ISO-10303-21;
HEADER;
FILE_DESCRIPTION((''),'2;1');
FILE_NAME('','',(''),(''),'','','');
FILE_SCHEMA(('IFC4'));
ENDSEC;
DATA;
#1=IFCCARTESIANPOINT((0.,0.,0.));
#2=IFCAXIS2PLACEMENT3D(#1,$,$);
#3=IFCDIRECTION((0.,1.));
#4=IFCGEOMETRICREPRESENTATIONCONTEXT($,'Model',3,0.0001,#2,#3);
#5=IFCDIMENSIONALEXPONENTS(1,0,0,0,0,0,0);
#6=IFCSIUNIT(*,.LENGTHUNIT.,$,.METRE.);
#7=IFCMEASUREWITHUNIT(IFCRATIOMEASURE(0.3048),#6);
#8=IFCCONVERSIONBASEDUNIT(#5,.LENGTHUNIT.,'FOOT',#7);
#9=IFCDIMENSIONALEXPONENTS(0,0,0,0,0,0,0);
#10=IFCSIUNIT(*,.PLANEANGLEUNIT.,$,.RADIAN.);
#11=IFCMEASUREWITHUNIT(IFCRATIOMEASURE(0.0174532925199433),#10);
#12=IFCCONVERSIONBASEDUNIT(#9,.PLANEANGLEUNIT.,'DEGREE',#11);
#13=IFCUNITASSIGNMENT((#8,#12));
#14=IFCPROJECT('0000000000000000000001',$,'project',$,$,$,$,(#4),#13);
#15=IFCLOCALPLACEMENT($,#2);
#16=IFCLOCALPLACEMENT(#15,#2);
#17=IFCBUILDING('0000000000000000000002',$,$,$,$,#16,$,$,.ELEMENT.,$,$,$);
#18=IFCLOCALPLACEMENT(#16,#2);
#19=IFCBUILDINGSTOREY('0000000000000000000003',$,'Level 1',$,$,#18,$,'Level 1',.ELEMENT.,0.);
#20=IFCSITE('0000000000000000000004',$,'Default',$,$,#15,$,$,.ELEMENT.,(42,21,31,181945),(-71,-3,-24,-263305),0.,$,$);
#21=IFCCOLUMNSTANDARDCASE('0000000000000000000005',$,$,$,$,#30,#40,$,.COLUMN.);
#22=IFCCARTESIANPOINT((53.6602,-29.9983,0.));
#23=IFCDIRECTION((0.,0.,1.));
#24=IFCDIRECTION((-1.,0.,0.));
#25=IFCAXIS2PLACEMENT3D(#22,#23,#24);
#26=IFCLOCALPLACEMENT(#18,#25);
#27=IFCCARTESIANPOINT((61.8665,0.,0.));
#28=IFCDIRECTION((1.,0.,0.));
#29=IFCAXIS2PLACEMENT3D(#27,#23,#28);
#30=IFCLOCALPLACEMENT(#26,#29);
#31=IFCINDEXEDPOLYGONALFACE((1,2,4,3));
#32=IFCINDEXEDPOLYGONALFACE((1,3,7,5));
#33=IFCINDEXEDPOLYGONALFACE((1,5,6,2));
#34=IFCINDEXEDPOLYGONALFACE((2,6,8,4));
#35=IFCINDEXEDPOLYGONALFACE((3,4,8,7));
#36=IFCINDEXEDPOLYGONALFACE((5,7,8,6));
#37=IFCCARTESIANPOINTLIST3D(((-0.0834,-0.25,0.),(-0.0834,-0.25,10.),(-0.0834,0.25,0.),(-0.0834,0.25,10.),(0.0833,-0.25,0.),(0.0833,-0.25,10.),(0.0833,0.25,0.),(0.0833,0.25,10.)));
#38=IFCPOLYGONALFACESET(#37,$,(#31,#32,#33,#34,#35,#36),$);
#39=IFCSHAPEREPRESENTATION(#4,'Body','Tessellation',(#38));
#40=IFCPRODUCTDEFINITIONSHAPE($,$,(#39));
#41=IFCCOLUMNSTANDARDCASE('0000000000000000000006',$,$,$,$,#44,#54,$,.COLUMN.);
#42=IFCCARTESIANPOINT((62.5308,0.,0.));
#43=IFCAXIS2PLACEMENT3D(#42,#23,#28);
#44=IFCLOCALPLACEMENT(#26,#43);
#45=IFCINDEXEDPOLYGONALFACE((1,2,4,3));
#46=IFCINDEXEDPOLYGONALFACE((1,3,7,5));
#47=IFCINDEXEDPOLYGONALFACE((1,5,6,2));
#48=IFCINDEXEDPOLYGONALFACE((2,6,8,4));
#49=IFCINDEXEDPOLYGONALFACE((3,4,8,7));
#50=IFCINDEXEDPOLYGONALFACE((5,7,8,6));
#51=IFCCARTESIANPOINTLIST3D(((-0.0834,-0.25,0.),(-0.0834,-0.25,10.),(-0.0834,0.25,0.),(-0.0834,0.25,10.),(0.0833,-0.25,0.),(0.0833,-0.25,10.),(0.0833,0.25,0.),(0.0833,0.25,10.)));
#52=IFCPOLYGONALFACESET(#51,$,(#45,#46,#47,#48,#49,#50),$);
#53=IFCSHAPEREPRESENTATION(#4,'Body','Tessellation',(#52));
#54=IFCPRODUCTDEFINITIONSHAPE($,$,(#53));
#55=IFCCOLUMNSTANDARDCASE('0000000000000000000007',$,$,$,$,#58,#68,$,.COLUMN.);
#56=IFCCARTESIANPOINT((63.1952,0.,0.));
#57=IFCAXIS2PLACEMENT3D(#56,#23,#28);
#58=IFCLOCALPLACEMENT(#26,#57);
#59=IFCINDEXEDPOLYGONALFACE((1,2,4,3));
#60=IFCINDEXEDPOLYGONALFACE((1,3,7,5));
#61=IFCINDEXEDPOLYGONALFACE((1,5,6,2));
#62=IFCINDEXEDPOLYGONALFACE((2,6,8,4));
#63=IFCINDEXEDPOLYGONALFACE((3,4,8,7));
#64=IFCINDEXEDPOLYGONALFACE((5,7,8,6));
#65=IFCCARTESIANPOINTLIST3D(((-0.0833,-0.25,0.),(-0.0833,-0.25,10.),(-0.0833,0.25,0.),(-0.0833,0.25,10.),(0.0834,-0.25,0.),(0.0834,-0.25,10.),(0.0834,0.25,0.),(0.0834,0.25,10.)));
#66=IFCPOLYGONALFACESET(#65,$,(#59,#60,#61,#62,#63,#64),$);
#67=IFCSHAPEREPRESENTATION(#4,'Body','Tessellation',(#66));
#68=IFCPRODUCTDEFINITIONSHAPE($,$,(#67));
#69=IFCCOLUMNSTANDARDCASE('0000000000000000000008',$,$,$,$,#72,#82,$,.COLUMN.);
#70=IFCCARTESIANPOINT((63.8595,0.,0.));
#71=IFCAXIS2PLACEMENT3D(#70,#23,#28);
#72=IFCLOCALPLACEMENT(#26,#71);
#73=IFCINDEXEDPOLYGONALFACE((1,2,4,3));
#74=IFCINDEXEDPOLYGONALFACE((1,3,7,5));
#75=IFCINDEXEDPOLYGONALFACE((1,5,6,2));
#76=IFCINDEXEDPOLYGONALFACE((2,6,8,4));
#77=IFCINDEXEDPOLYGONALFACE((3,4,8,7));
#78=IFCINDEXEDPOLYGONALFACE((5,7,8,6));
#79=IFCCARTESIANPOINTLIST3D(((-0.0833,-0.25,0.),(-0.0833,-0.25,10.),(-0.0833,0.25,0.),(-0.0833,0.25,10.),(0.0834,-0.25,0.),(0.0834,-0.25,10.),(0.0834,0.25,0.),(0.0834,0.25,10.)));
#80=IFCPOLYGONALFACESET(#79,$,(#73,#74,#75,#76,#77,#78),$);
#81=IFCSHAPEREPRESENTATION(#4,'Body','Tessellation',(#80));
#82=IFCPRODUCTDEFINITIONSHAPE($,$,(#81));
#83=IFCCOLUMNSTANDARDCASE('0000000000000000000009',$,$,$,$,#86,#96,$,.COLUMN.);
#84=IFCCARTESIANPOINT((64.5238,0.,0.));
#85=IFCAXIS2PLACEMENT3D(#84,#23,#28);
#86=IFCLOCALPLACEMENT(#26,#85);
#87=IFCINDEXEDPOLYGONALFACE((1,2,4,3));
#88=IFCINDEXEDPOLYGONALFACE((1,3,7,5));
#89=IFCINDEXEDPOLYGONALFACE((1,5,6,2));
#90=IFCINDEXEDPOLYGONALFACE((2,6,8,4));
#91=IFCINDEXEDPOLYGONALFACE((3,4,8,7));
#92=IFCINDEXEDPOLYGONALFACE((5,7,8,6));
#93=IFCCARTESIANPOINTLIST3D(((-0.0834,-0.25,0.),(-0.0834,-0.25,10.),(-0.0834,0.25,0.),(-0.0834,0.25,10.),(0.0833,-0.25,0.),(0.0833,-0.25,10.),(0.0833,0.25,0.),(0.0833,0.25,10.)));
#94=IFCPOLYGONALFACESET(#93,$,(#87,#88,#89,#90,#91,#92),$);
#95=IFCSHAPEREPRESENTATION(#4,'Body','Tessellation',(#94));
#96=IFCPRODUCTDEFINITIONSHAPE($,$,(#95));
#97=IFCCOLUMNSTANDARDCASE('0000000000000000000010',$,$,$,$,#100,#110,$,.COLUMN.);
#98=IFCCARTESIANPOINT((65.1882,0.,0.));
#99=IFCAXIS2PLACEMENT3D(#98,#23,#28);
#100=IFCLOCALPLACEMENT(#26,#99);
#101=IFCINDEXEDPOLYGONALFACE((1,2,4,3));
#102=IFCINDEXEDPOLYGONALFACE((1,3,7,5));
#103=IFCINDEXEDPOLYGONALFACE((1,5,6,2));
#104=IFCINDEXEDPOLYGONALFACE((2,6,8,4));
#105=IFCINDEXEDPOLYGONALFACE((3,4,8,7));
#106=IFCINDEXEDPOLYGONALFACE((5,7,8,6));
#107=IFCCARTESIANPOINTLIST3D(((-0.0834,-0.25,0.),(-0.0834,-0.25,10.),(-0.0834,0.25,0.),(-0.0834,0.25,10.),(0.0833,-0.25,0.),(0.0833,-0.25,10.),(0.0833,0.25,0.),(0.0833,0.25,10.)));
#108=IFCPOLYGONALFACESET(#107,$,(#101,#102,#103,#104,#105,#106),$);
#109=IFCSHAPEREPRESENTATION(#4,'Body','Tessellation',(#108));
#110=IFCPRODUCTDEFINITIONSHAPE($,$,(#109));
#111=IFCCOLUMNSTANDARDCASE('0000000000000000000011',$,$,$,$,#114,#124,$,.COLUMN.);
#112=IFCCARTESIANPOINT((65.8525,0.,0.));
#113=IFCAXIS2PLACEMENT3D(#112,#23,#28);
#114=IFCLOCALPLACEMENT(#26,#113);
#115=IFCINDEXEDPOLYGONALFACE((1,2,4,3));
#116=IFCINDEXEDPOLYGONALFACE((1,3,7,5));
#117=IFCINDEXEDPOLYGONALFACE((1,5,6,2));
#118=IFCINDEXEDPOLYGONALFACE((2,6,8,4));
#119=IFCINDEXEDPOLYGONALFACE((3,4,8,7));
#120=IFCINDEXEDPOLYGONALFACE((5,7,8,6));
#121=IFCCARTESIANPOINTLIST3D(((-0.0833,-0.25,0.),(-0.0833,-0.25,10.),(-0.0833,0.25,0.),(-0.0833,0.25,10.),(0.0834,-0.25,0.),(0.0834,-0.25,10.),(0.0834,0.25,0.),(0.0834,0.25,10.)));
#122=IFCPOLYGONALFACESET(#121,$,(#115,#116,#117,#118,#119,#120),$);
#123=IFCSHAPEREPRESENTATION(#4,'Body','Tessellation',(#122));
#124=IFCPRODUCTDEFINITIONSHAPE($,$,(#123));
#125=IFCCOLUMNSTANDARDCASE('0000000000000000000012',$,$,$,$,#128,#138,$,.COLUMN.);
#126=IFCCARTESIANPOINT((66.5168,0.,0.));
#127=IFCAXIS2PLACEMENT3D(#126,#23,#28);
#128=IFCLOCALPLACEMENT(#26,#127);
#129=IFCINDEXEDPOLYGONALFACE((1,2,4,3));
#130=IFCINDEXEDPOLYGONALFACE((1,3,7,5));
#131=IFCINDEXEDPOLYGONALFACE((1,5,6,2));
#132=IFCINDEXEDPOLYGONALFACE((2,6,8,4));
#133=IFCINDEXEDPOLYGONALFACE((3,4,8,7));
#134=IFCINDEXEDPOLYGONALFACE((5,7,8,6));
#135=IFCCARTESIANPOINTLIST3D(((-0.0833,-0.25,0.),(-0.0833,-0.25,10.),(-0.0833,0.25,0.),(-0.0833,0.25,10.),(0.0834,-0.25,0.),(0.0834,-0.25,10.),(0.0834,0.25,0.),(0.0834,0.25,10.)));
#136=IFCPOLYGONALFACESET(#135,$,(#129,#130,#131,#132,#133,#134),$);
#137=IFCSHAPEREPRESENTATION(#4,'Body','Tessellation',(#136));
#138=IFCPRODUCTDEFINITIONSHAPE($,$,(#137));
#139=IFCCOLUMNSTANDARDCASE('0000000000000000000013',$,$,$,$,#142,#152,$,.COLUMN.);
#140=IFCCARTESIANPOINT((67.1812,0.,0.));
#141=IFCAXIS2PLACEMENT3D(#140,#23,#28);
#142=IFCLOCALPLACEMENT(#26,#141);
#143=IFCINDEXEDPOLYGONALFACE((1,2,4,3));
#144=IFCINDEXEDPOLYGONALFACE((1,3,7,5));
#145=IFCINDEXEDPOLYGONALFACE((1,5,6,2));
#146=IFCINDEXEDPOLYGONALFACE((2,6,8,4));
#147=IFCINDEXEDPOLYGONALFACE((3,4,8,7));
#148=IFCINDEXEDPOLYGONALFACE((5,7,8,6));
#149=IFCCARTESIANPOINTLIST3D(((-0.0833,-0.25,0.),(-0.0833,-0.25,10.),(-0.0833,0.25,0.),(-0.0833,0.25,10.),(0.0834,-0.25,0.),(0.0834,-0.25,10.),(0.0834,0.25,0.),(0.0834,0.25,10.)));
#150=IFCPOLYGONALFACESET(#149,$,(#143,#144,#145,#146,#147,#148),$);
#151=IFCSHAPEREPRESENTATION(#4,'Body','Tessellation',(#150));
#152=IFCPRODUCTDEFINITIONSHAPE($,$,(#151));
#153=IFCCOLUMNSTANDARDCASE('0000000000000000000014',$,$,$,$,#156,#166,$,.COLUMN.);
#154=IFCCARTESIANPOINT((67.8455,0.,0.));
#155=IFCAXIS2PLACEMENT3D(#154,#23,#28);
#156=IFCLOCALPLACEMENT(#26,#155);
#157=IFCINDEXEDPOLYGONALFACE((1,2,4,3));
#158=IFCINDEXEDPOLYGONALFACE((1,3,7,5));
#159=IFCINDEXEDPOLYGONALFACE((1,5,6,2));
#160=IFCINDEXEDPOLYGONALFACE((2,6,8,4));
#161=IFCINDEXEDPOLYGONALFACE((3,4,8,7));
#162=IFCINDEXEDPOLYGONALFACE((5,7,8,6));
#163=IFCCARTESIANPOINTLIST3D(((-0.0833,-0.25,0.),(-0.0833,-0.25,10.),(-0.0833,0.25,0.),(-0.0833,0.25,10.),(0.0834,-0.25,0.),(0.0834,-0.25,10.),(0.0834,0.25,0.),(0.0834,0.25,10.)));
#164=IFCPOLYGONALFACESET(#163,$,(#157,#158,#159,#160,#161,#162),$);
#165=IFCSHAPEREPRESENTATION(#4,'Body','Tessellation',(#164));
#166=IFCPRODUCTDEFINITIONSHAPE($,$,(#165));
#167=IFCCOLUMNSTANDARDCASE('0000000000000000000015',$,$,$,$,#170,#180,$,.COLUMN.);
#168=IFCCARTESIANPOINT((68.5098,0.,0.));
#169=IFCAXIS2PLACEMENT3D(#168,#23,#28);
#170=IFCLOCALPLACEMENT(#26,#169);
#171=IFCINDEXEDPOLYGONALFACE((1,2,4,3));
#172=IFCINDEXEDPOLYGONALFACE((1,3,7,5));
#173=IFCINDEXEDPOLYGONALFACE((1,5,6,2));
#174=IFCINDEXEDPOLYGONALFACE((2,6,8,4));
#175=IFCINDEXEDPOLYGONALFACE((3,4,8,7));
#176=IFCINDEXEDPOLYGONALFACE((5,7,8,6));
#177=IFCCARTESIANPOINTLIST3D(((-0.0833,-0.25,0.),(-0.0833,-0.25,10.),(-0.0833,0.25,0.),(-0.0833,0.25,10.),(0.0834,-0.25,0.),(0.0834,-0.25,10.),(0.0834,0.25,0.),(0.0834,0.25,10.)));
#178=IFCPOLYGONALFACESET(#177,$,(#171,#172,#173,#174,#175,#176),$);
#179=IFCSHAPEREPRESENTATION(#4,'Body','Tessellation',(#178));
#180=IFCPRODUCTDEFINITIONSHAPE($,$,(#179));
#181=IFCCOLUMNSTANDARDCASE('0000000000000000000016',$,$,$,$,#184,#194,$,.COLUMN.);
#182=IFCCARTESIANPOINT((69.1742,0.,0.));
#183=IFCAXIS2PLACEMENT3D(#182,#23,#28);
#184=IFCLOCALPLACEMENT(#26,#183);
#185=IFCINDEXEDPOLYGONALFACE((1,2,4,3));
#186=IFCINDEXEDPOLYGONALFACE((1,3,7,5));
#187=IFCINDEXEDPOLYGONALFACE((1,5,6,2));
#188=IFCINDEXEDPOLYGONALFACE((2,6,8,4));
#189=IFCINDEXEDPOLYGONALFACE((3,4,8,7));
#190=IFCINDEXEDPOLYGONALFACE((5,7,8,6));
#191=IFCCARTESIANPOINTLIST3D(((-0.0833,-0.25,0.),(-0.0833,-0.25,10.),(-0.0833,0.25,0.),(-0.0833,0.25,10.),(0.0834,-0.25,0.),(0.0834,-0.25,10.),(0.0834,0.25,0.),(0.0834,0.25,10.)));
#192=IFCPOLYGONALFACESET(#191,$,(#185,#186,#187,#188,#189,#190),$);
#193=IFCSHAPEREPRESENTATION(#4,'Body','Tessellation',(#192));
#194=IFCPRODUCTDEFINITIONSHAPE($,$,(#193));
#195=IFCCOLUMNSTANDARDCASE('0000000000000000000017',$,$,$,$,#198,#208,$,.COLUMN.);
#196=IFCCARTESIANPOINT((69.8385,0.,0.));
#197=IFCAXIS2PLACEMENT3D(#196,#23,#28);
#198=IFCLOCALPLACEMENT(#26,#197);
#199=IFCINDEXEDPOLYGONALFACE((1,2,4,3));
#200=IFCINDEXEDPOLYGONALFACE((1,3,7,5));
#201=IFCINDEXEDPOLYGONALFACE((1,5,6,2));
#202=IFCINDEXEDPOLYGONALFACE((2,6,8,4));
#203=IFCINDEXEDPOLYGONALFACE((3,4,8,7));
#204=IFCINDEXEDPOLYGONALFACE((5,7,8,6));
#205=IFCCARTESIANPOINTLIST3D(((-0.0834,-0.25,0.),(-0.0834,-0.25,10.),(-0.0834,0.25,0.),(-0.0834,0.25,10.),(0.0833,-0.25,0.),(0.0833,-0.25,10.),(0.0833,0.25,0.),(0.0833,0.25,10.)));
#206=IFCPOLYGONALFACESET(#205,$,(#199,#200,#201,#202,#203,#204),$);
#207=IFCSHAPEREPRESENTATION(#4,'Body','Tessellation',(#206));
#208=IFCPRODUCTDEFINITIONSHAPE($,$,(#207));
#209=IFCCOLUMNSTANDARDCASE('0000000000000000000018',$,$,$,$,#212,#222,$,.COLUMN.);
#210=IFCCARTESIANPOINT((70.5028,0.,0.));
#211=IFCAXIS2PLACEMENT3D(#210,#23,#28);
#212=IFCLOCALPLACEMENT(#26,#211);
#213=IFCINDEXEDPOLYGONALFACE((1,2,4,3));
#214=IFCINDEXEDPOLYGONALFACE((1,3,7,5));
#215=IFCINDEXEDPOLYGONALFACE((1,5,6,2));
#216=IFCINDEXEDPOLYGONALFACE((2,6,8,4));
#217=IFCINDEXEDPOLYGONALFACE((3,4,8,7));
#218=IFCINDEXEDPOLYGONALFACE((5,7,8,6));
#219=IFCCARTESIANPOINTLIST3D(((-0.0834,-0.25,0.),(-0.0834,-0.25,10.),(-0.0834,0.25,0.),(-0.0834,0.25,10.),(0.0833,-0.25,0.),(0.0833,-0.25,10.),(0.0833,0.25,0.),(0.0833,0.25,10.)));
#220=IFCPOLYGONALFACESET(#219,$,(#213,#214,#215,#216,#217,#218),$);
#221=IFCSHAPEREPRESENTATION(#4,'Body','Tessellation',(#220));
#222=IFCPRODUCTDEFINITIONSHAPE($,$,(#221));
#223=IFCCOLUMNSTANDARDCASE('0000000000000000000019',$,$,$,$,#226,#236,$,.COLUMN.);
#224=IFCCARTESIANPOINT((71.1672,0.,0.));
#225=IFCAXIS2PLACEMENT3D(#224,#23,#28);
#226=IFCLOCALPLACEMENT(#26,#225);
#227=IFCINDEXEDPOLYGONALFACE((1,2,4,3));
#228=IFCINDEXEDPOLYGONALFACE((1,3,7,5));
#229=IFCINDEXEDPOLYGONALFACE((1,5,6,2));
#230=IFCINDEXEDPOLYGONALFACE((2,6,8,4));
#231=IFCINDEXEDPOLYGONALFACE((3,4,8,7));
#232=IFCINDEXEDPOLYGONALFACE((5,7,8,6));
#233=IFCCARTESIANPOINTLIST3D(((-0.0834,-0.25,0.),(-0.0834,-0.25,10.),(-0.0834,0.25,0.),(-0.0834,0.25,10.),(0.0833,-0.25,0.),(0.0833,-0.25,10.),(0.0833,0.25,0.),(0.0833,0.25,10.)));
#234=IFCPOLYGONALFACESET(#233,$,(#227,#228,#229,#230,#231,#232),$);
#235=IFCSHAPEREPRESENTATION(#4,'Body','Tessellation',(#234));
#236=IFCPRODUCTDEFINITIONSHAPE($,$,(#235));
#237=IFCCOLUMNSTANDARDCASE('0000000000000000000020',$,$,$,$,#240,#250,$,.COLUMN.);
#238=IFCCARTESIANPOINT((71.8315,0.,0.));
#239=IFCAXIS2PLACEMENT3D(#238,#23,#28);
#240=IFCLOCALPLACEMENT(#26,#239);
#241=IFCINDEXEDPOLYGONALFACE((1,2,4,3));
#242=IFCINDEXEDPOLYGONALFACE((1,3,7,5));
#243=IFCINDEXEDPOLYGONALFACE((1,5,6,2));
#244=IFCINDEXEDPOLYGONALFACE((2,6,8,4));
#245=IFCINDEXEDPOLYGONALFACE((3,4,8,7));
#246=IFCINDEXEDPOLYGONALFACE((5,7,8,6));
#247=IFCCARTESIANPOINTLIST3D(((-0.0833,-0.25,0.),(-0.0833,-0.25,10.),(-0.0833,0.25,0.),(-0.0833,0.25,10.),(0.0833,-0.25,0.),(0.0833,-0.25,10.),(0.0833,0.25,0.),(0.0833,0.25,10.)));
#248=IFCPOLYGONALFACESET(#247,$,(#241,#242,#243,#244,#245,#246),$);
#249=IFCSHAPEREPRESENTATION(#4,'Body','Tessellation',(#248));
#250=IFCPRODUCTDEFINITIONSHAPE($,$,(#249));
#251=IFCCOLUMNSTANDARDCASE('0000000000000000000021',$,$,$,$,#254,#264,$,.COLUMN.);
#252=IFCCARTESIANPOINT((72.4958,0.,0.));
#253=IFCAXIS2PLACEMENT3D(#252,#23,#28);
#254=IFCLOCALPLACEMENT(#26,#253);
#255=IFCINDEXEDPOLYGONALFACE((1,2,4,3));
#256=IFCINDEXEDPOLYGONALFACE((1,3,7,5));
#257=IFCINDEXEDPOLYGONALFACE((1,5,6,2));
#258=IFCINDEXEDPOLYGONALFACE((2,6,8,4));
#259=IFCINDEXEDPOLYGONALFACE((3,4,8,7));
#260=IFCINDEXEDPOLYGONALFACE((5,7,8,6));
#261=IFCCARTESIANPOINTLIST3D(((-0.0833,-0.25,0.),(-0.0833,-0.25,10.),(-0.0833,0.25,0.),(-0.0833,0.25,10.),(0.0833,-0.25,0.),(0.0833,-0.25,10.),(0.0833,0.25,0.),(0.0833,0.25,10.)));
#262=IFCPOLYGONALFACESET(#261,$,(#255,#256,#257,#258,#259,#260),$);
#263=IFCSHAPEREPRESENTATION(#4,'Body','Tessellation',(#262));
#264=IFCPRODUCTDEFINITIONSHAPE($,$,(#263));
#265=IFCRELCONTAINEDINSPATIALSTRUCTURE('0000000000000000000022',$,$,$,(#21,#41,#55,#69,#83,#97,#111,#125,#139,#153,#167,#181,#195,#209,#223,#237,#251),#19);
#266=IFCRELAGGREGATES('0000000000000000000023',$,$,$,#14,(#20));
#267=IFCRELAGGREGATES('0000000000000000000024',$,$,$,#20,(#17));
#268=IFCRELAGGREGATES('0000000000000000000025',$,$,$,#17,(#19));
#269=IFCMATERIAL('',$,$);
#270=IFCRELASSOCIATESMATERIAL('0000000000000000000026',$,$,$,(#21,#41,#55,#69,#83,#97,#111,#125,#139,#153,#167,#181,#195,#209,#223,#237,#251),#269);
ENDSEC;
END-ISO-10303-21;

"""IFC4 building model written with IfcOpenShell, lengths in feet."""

from ifc_helpers import new_model, entity, si_unit, converted_unit, direction, frame, origin, place, context, project, spatial, rectangle, extrude, material, element, save


model = new_model("IFC4")

# Units and contexts
model_context = context("Model", 3, precision=0.0001, world=origin(), true_north=direction((0.0, 1.0)))
ifc_project = project(units=[converted_unit("LENGTHUNIT", "FOOT", entity("IfcRatioMeasure", 0.3048), si_unit("LENGTHUNIT", "METRE"), dimensions=[1, 0, 0, 0, 0, 0, 0]), converted_unit("PLANEANGLEUNIT", "DEGREE", entity("IfcRatioMeasure", 0.0174532925199433), si_unit("PLANEANGLEUNIT", "RADIAN"), dimensions=[0, 0, 0, 0, 0, 0, 0])], contexts=[model_context])

# Site, building, storey
site_placement = place(None, origin())
site = spatial("IfcSite", under=ifc_project, at=site_placement, Name="Default", CompositionType="ELEMENT", RefLatitude=(42, 21, 31, 181945), RefLongitude=(-71, -3, -24, -263305), RefElevation=0.0)
building_placement = place(site_placement, origin())
building = spatial("IfcBuilding", under=site, at=building_placement, CompositionType="ELEMENT")
storey_placement = place(building_placement, origin())
storey = spatial("IfcBuildingStorey", under=building, at=storey_placement, Name="Level 1", LongName="Level 1", CompositionType="ELEMENT", Elevation=0.0)

# Columns
ifc_material = material(Name="")
placement = place(storey_placement, frame((53.6602, -29.9983, 0.0), z_axis=(0.0, 0.0, 1.0), x_axis=(-1.0, 0.0, 0.0)))
for number, where, z_axis, x_axis in (
    (1, (61.8665, 0.0, 0.0), (0.0, 0.0, 1.0), (1.0, 0.0, 0.0)),
    (2, (62.5308, 0.0, 0.0), (0.0, 0.0, 1.0), (1.0, 0.0, 0.0)),
    (3, (63.1952, 0.0, 0.0), (0.0, 0.0, 1.0), (1.0, 0.0, 0.0)),
    (4, (63.8595, 0.0, 0.0), (0.0, 0.0, 1.0), (1.0, 0.0, 0.0)),
    (5, (64.5238, 0.0, 0.0), (0.0, 0.0, 1.0), (1.0, 0.0, 0.0)),
    (6, (65.1882, 0.0, 0.0), (0.0, 0.0, 1.0), (1.0, 0.0, 0.0)),
    (7, (65.8525, 0.0, 0.0), (0.0, 0.0, 1.0), (1.0, 0.0, 0.0)),
    (8, (66.5168, 0.0, 0.0), (0.0, 0.0, 1.0), (1.0, 0.0, 0.0)),
    (9, (67.1812, 0.0, 0.0), (0.0, 0.0, 1.0), (1.0, 0.0, 0.0)),
    (10, (67.8455, 0.0, 0.0), (0.0, 0.0, 1.0), (1.0, 0.0, 0.0)),
    (11, (68.5098, 0.0, 0.0), (0.0, 0.0, 1.0), (1.0, 0.0, 0.0)),
    (12, (69.1742, 0.0, 0.0), (0.0, 0.0, 1.0), (1.0, 0.0, 0.0)),
    (13, (69.8385, 0.0, 0.0), (0.0, 0.0, 1.0), (1.0, 0.0, 0.0)),
    (14, (70.5028, 0.0, 0.0), (0.0, 0.0, 1.0), (1.0, 0.0, 0.0)),
    (15, (71.1672, 0.0, 0.0), (0.0, 0.0, 1.0), (1.0, 0.0, 0.0)),
    (16, (71.8315, 0.0, 0.0), (0.0, 0.0, 1.0), (1.0, 0.0, 0.0)),
    (17, (72.4958, 0.0, 0.0), (0.0, 0.0, 1.0), (1.0, 0.0, 0.0)),
):
    element("IfcColumnStandardCase", number, at=place(placement, frame(where, z_axis=z_axis, x_axis=x_axis)), inside=storey, material=ifc_material, PredefinedType="COLUMN", context=model_context, shape_type="SweptSolid", body=[
        extrude(rectangle(XDim=0.1667, YDim=0.5), origin(), (0.0, 0.0, 1.0), 10.0),
    ])

save(model, "model.ifc")
